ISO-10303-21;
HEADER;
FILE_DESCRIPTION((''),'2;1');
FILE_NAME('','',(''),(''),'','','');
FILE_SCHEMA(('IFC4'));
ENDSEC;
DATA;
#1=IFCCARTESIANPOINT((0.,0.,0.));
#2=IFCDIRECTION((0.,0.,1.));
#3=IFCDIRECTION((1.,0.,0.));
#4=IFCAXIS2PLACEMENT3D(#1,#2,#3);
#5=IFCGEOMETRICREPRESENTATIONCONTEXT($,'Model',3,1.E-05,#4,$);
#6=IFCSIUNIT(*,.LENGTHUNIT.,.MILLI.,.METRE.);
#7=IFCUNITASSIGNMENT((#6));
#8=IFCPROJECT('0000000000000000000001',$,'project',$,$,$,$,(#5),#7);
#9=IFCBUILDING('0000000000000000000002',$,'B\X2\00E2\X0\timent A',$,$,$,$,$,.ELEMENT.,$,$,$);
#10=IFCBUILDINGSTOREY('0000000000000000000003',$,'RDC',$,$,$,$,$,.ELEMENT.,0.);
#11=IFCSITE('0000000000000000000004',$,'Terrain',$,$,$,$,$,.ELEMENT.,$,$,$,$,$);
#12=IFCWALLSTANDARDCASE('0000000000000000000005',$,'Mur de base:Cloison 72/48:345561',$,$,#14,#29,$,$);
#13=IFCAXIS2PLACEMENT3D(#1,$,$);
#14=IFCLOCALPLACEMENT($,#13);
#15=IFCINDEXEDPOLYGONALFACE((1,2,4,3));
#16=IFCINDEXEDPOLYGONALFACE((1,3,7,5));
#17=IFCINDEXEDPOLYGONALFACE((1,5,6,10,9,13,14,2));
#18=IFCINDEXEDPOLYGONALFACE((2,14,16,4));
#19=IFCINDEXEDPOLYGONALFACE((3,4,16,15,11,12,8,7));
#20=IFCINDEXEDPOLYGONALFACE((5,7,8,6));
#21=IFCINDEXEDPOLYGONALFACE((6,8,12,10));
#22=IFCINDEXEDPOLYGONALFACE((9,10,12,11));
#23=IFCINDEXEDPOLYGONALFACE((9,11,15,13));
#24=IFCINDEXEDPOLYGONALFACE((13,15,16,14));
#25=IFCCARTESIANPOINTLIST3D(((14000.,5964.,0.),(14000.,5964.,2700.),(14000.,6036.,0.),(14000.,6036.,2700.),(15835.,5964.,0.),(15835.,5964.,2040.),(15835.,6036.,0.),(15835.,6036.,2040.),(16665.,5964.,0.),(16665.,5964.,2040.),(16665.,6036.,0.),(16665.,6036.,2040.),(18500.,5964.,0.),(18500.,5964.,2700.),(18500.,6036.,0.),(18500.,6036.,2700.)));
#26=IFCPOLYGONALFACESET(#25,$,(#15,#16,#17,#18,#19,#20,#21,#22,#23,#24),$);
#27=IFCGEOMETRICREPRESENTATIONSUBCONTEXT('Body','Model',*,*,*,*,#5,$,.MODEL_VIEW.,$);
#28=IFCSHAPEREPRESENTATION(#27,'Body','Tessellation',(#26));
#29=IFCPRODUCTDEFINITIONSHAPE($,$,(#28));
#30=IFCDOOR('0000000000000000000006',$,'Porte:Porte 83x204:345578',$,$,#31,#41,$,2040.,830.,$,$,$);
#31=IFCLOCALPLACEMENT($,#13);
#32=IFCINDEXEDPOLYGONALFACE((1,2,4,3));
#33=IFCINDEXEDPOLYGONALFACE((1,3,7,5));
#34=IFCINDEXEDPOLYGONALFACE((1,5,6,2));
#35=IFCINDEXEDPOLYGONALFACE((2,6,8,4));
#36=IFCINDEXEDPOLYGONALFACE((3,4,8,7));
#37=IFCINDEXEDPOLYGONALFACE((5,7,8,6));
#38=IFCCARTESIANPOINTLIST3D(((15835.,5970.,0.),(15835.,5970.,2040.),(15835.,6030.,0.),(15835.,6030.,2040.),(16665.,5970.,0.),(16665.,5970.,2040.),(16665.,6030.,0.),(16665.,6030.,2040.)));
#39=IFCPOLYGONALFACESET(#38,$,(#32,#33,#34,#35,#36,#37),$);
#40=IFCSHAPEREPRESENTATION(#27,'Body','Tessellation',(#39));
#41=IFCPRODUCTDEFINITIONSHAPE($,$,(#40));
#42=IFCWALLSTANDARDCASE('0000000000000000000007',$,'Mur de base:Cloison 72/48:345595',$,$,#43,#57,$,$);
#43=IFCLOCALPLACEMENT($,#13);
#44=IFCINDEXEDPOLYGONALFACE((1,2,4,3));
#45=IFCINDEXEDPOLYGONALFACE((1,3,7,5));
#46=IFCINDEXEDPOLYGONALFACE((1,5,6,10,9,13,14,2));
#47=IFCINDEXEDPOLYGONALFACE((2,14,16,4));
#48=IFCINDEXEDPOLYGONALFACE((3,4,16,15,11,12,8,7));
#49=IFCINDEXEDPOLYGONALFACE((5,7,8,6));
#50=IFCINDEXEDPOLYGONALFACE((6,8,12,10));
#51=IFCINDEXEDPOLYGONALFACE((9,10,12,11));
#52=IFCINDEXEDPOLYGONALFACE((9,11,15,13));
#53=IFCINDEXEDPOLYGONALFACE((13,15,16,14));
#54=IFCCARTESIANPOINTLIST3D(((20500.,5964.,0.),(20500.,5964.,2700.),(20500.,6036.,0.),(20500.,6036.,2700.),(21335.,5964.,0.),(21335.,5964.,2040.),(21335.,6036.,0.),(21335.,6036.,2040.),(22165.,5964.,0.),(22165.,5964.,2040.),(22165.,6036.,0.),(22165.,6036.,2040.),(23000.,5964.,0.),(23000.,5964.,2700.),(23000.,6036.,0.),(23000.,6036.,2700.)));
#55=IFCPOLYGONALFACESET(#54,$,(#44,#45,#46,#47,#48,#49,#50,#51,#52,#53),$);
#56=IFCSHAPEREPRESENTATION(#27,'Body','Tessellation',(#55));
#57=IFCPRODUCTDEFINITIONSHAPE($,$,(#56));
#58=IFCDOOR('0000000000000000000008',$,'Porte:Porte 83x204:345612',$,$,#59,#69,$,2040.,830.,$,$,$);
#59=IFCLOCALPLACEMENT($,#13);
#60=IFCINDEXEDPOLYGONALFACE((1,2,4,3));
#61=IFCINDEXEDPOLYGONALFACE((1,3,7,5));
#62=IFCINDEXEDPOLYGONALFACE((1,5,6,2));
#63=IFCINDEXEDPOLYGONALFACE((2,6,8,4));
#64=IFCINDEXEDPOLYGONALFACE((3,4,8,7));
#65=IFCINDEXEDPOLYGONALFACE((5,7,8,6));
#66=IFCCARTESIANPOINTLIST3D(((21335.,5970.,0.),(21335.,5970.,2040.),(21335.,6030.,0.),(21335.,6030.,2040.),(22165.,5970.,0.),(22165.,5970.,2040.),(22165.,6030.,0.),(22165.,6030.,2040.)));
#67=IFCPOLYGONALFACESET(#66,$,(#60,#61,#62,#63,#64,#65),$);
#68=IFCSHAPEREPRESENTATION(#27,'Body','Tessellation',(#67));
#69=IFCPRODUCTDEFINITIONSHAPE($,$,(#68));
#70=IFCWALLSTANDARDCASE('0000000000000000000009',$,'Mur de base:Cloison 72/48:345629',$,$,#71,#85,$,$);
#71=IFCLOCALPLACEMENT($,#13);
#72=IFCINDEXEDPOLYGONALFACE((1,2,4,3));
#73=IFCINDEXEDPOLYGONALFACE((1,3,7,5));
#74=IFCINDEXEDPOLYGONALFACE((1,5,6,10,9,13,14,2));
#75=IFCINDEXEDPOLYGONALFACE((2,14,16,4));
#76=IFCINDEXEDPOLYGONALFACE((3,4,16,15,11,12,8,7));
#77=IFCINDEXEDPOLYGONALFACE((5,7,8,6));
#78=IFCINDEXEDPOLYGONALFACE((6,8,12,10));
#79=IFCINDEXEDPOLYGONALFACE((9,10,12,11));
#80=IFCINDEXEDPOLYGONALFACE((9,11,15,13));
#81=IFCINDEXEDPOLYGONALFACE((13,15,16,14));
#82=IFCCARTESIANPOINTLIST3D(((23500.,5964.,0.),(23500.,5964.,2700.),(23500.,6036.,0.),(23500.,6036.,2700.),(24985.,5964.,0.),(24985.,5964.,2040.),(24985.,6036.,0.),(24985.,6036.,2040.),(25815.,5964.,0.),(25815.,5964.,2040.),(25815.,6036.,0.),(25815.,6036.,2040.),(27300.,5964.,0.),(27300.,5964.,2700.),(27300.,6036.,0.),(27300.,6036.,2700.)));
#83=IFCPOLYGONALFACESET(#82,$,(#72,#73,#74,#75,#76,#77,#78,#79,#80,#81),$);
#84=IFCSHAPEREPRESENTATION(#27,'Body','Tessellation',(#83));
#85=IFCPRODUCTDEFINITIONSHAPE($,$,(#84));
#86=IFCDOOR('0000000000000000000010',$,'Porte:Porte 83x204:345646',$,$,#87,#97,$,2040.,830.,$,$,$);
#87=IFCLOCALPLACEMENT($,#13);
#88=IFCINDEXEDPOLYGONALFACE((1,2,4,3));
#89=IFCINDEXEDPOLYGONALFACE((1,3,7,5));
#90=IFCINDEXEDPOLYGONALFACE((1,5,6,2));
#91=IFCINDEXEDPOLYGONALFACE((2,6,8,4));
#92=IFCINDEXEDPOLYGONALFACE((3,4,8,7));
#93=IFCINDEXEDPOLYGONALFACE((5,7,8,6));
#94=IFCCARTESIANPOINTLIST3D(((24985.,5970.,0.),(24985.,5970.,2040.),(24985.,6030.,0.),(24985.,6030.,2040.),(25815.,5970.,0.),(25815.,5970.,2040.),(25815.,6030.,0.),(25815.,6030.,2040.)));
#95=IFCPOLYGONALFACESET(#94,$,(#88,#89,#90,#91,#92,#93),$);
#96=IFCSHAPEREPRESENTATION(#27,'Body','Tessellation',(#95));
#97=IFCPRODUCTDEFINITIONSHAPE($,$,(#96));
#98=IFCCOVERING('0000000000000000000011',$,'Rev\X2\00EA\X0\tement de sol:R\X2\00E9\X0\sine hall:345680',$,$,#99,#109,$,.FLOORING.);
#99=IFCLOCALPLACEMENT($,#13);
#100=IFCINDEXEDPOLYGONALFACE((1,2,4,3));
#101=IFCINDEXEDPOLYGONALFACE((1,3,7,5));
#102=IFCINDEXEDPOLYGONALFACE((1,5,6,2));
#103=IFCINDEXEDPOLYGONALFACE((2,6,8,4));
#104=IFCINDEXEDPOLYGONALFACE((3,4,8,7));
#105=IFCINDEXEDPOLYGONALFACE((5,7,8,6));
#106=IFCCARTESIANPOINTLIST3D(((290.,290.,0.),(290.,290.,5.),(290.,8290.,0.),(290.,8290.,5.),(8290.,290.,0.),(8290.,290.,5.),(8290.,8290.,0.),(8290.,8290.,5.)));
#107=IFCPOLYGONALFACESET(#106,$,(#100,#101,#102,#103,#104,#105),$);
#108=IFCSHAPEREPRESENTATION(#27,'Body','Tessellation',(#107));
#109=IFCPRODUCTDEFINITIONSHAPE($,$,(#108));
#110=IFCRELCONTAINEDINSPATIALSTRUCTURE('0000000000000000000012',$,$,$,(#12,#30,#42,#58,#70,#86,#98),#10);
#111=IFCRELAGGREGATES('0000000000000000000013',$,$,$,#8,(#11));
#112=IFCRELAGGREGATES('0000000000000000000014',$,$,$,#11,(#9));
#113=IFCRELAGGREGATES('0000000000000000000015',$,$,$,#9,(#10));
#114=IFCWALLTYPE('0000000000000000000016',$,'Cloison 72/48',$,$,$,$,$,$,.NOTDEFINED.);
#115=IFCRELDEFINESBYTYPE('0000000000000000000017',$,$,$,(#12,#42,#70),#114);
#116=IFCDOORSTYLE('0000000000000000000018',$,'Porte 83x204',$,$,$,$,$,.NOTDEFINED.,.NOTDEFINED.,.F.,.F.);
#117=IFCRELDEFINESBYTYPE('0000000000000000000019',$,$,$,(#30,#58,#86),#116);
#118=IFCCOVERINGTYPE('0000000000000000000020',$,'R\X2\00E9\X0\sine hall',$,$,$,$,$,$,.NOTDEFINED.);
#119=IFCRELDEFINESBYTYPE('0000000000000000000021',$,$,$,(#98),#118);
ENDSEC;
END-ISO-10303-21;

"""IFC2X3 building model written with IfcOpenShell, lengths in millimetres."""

from ifc_helpers import new_model, si_unit, frame_2d, origin_with_axes, place, context, subcontext, project, spatial, rectangle, extrude, type_object, element, fill, save


model = new_model("IFC2X3")

# Units and contexts
model_context = context("Model", 3, precision=1e-05, world=origin_with_axes())
body_context = subcontext(model_context, "Body", "Model", "MODEL_VIEW")
ifc_project = project(units=[si_unit("LENGTHUNIT", "METRE", prefix="MILLI")], contexts=[model_context])

# Site, building, storey
site = spatial("IfcSite", under=ifc_project, Name="Terrain", CompositionType="ELEMENT")
building = spatial("IfcBuilding", under=site, Name="Bâtiment A", CompositionType="ELEMENT")
storey = spatial("IfcBuildingStorey", under=building, Name="RDC", CompositionType="ELEMENT", Elevation=0.0)

# Walls, openings, doors
door_style = type_object("IfcDoorStyle", Name="Porte 83x204", ConstructionType="NOTDEFINED", OperationType="NOTDEFINED", ParameterTakesPrecedence=False, Sizeable=False)
wall_type_1 = type_object("IfcWallType", Name="Cloison 72/48", PredefinedType="NOTDEFINED")
wall_1_placement = place(None, origin_with_axes())
wall_1 = element("IfcWallStandardCase", 1, at=wall_1_placement, inside=storey, type_object=wall_type_1, Name="Mur de base:Cloison 72/48:345561", context=body_context, shape_type="SweptSolid", body=[
    extrude(rectangle(XDim=4500.0, YDim=72.0, at=frame_2d((16250.0, 6000.0))), origin_with_axes(), (0.0, 0.0, 1.0), 2700.0),
])
opening_1_placement = place(None, origin_with_axes())
opening_1 = element("IfcOpeningElement", 2, at=opening_1_placement, cuts=wall_1, context=body_context, shape_type="SweptSolid", body=[
    extrude(rectangle(XDim=830.0, YDim=192.0, at=frame_2d((16250.0, 6000.0))), origin_with_axes(), (0.0, 0.0, 1.0), 2040.0),
])
door_1_placement = place(None, origin_with_axes())
door_1 = element("IfcDoor", 3, at=door_1_placement, inside=storey, type_object=door_style, Name="Porte:Porte 83x204:345578", OverallHeight=2040.0, OverallWidth=830.0, context=body_context, shape_type="SweptSolid", body=[
    extrude(rectangle(XDim=830.0, YDim=60.0, at=frame_2d((16250.0, 6000.0))), origin_with_axes(), (0.0, 0.0, 1.0), 2040.0),
])
fill(opening_1, door_1)
wall_2_placement = place(None, origin_with_axes())
wall_2 = element("IfcWallStandardCase", 4, at=wall_2_placement, inside=storey, type_object=wall_type_1, Name="Mur de base:Cloison 72/48:345595", context=body_context, shape_type="SweptSolid", body=[
    extrude(rectangle(XDim=2500.0, YDim=72.0, at=frame_2d((21750.0, 6000.0))), origin_with_axes(), (0.0, 0.0, 1.0), 2700.0),
])
opening_2_placement = place(None, origin_with_axes())
opening_2 = element("IfcOpeningElement", 5, at=opening_2_placement, cuts=wall_2, context=body_context, shape_type="SweptSolid", body=[
    extrude(rectangle(XDim=830.0, YDim=192.0, at=frame_2d((21750.0, 6000.0))), origin_with_axes(), (0.0, 0.0, 1.0), 2040.0),
])
door_2_placement = place(None, origin_with_axes())
door_2 = element("IfcDoor", 6, at=door_2_placement, inside=storey, type_object=door_style, Name="Porte:Porte 83x204:345612", OverallHeight=2040.0, OverallWidth=830.0, context=body_context, shape_type="SweptSolid", body=[
    extrude(rectangle(XDim=830.0, YDim=60.0, at=frame_2d((21750.0, 6000.0))), origin_with_axes(), (0.0, 0.0, 1.0), 2040.0),
])
fill(opening_2, door_2)
wall_3_placement = place(None, origin_with_axes())
wall_3 = element("IfcWallStandardCase", 7, at=wall_3_placement, inside=storey, type_object=wall_type_1, Name="Mur de base:Cloison 72/48:345629", context=body_context, shape_type="SweptSolid", body=[
    extrude(rectangle(XDim=3800.0, YDim=72.0, at=frame_2d((25400.0, 6000.0))), origin_with_axes(), (0.0, 0.0, 1.0), 2700.0),
])
opening_3_placement = place(None, origin_with_axes())
opening_3 = element("IfcOpeningElement", 8, at=opening_3_placement, cuts=wall_3, context=body_context, shape_type="SweptSolid", body=[
    extrude(rectangle(XDim=830.0, YDim=192.0, at=frame_2d((25400.0, 6000.0))), origin_with_axes(), (0.0, 0.0, 1.0), 2040.0),
])
door_3_placement = place(None, origin_with_axes())
door_3 = element("IfcDoor", 9, at=door_3_placement, inside=storey, type_object=door_style, Name="Porte:Porte 83x204:345646", OverallHeight=2040.0, OverallWidth=830.0, context=body_context, shape_type="SweptSolid", body=[
    extrude(rectangle(XDim=830.0, YDim=60.0, at=frame_2d((25400.0, 6000.0))), origin_with_axes(), (0.0, 0.0, 1.0), 2040.0),
])
fill(opening_3, door_3)

# Covering
covering_type = type_object("IfcCoveringType", Name="Résine hall", PredefinedType="NOTDEFINED")
covering_placement = place(None, origin_with_axes())
element("IfcCovering", 10, at=covering_placement, inside=storey, type_object=covering_type, Name="Revêtement de sol:Résine hall:345680", PredefinedType="FLOORING", context=body_context, shape_type="SweptSolid", body=[
    extrude(rectangle(XDim=8000.0, YDim=8000.0, at=frame_2d((4290.0, 4290.0))), origin_with_axes(), (0.0, 0.0, 1.0), 5.0),
])

save(model, "model.ifc")
